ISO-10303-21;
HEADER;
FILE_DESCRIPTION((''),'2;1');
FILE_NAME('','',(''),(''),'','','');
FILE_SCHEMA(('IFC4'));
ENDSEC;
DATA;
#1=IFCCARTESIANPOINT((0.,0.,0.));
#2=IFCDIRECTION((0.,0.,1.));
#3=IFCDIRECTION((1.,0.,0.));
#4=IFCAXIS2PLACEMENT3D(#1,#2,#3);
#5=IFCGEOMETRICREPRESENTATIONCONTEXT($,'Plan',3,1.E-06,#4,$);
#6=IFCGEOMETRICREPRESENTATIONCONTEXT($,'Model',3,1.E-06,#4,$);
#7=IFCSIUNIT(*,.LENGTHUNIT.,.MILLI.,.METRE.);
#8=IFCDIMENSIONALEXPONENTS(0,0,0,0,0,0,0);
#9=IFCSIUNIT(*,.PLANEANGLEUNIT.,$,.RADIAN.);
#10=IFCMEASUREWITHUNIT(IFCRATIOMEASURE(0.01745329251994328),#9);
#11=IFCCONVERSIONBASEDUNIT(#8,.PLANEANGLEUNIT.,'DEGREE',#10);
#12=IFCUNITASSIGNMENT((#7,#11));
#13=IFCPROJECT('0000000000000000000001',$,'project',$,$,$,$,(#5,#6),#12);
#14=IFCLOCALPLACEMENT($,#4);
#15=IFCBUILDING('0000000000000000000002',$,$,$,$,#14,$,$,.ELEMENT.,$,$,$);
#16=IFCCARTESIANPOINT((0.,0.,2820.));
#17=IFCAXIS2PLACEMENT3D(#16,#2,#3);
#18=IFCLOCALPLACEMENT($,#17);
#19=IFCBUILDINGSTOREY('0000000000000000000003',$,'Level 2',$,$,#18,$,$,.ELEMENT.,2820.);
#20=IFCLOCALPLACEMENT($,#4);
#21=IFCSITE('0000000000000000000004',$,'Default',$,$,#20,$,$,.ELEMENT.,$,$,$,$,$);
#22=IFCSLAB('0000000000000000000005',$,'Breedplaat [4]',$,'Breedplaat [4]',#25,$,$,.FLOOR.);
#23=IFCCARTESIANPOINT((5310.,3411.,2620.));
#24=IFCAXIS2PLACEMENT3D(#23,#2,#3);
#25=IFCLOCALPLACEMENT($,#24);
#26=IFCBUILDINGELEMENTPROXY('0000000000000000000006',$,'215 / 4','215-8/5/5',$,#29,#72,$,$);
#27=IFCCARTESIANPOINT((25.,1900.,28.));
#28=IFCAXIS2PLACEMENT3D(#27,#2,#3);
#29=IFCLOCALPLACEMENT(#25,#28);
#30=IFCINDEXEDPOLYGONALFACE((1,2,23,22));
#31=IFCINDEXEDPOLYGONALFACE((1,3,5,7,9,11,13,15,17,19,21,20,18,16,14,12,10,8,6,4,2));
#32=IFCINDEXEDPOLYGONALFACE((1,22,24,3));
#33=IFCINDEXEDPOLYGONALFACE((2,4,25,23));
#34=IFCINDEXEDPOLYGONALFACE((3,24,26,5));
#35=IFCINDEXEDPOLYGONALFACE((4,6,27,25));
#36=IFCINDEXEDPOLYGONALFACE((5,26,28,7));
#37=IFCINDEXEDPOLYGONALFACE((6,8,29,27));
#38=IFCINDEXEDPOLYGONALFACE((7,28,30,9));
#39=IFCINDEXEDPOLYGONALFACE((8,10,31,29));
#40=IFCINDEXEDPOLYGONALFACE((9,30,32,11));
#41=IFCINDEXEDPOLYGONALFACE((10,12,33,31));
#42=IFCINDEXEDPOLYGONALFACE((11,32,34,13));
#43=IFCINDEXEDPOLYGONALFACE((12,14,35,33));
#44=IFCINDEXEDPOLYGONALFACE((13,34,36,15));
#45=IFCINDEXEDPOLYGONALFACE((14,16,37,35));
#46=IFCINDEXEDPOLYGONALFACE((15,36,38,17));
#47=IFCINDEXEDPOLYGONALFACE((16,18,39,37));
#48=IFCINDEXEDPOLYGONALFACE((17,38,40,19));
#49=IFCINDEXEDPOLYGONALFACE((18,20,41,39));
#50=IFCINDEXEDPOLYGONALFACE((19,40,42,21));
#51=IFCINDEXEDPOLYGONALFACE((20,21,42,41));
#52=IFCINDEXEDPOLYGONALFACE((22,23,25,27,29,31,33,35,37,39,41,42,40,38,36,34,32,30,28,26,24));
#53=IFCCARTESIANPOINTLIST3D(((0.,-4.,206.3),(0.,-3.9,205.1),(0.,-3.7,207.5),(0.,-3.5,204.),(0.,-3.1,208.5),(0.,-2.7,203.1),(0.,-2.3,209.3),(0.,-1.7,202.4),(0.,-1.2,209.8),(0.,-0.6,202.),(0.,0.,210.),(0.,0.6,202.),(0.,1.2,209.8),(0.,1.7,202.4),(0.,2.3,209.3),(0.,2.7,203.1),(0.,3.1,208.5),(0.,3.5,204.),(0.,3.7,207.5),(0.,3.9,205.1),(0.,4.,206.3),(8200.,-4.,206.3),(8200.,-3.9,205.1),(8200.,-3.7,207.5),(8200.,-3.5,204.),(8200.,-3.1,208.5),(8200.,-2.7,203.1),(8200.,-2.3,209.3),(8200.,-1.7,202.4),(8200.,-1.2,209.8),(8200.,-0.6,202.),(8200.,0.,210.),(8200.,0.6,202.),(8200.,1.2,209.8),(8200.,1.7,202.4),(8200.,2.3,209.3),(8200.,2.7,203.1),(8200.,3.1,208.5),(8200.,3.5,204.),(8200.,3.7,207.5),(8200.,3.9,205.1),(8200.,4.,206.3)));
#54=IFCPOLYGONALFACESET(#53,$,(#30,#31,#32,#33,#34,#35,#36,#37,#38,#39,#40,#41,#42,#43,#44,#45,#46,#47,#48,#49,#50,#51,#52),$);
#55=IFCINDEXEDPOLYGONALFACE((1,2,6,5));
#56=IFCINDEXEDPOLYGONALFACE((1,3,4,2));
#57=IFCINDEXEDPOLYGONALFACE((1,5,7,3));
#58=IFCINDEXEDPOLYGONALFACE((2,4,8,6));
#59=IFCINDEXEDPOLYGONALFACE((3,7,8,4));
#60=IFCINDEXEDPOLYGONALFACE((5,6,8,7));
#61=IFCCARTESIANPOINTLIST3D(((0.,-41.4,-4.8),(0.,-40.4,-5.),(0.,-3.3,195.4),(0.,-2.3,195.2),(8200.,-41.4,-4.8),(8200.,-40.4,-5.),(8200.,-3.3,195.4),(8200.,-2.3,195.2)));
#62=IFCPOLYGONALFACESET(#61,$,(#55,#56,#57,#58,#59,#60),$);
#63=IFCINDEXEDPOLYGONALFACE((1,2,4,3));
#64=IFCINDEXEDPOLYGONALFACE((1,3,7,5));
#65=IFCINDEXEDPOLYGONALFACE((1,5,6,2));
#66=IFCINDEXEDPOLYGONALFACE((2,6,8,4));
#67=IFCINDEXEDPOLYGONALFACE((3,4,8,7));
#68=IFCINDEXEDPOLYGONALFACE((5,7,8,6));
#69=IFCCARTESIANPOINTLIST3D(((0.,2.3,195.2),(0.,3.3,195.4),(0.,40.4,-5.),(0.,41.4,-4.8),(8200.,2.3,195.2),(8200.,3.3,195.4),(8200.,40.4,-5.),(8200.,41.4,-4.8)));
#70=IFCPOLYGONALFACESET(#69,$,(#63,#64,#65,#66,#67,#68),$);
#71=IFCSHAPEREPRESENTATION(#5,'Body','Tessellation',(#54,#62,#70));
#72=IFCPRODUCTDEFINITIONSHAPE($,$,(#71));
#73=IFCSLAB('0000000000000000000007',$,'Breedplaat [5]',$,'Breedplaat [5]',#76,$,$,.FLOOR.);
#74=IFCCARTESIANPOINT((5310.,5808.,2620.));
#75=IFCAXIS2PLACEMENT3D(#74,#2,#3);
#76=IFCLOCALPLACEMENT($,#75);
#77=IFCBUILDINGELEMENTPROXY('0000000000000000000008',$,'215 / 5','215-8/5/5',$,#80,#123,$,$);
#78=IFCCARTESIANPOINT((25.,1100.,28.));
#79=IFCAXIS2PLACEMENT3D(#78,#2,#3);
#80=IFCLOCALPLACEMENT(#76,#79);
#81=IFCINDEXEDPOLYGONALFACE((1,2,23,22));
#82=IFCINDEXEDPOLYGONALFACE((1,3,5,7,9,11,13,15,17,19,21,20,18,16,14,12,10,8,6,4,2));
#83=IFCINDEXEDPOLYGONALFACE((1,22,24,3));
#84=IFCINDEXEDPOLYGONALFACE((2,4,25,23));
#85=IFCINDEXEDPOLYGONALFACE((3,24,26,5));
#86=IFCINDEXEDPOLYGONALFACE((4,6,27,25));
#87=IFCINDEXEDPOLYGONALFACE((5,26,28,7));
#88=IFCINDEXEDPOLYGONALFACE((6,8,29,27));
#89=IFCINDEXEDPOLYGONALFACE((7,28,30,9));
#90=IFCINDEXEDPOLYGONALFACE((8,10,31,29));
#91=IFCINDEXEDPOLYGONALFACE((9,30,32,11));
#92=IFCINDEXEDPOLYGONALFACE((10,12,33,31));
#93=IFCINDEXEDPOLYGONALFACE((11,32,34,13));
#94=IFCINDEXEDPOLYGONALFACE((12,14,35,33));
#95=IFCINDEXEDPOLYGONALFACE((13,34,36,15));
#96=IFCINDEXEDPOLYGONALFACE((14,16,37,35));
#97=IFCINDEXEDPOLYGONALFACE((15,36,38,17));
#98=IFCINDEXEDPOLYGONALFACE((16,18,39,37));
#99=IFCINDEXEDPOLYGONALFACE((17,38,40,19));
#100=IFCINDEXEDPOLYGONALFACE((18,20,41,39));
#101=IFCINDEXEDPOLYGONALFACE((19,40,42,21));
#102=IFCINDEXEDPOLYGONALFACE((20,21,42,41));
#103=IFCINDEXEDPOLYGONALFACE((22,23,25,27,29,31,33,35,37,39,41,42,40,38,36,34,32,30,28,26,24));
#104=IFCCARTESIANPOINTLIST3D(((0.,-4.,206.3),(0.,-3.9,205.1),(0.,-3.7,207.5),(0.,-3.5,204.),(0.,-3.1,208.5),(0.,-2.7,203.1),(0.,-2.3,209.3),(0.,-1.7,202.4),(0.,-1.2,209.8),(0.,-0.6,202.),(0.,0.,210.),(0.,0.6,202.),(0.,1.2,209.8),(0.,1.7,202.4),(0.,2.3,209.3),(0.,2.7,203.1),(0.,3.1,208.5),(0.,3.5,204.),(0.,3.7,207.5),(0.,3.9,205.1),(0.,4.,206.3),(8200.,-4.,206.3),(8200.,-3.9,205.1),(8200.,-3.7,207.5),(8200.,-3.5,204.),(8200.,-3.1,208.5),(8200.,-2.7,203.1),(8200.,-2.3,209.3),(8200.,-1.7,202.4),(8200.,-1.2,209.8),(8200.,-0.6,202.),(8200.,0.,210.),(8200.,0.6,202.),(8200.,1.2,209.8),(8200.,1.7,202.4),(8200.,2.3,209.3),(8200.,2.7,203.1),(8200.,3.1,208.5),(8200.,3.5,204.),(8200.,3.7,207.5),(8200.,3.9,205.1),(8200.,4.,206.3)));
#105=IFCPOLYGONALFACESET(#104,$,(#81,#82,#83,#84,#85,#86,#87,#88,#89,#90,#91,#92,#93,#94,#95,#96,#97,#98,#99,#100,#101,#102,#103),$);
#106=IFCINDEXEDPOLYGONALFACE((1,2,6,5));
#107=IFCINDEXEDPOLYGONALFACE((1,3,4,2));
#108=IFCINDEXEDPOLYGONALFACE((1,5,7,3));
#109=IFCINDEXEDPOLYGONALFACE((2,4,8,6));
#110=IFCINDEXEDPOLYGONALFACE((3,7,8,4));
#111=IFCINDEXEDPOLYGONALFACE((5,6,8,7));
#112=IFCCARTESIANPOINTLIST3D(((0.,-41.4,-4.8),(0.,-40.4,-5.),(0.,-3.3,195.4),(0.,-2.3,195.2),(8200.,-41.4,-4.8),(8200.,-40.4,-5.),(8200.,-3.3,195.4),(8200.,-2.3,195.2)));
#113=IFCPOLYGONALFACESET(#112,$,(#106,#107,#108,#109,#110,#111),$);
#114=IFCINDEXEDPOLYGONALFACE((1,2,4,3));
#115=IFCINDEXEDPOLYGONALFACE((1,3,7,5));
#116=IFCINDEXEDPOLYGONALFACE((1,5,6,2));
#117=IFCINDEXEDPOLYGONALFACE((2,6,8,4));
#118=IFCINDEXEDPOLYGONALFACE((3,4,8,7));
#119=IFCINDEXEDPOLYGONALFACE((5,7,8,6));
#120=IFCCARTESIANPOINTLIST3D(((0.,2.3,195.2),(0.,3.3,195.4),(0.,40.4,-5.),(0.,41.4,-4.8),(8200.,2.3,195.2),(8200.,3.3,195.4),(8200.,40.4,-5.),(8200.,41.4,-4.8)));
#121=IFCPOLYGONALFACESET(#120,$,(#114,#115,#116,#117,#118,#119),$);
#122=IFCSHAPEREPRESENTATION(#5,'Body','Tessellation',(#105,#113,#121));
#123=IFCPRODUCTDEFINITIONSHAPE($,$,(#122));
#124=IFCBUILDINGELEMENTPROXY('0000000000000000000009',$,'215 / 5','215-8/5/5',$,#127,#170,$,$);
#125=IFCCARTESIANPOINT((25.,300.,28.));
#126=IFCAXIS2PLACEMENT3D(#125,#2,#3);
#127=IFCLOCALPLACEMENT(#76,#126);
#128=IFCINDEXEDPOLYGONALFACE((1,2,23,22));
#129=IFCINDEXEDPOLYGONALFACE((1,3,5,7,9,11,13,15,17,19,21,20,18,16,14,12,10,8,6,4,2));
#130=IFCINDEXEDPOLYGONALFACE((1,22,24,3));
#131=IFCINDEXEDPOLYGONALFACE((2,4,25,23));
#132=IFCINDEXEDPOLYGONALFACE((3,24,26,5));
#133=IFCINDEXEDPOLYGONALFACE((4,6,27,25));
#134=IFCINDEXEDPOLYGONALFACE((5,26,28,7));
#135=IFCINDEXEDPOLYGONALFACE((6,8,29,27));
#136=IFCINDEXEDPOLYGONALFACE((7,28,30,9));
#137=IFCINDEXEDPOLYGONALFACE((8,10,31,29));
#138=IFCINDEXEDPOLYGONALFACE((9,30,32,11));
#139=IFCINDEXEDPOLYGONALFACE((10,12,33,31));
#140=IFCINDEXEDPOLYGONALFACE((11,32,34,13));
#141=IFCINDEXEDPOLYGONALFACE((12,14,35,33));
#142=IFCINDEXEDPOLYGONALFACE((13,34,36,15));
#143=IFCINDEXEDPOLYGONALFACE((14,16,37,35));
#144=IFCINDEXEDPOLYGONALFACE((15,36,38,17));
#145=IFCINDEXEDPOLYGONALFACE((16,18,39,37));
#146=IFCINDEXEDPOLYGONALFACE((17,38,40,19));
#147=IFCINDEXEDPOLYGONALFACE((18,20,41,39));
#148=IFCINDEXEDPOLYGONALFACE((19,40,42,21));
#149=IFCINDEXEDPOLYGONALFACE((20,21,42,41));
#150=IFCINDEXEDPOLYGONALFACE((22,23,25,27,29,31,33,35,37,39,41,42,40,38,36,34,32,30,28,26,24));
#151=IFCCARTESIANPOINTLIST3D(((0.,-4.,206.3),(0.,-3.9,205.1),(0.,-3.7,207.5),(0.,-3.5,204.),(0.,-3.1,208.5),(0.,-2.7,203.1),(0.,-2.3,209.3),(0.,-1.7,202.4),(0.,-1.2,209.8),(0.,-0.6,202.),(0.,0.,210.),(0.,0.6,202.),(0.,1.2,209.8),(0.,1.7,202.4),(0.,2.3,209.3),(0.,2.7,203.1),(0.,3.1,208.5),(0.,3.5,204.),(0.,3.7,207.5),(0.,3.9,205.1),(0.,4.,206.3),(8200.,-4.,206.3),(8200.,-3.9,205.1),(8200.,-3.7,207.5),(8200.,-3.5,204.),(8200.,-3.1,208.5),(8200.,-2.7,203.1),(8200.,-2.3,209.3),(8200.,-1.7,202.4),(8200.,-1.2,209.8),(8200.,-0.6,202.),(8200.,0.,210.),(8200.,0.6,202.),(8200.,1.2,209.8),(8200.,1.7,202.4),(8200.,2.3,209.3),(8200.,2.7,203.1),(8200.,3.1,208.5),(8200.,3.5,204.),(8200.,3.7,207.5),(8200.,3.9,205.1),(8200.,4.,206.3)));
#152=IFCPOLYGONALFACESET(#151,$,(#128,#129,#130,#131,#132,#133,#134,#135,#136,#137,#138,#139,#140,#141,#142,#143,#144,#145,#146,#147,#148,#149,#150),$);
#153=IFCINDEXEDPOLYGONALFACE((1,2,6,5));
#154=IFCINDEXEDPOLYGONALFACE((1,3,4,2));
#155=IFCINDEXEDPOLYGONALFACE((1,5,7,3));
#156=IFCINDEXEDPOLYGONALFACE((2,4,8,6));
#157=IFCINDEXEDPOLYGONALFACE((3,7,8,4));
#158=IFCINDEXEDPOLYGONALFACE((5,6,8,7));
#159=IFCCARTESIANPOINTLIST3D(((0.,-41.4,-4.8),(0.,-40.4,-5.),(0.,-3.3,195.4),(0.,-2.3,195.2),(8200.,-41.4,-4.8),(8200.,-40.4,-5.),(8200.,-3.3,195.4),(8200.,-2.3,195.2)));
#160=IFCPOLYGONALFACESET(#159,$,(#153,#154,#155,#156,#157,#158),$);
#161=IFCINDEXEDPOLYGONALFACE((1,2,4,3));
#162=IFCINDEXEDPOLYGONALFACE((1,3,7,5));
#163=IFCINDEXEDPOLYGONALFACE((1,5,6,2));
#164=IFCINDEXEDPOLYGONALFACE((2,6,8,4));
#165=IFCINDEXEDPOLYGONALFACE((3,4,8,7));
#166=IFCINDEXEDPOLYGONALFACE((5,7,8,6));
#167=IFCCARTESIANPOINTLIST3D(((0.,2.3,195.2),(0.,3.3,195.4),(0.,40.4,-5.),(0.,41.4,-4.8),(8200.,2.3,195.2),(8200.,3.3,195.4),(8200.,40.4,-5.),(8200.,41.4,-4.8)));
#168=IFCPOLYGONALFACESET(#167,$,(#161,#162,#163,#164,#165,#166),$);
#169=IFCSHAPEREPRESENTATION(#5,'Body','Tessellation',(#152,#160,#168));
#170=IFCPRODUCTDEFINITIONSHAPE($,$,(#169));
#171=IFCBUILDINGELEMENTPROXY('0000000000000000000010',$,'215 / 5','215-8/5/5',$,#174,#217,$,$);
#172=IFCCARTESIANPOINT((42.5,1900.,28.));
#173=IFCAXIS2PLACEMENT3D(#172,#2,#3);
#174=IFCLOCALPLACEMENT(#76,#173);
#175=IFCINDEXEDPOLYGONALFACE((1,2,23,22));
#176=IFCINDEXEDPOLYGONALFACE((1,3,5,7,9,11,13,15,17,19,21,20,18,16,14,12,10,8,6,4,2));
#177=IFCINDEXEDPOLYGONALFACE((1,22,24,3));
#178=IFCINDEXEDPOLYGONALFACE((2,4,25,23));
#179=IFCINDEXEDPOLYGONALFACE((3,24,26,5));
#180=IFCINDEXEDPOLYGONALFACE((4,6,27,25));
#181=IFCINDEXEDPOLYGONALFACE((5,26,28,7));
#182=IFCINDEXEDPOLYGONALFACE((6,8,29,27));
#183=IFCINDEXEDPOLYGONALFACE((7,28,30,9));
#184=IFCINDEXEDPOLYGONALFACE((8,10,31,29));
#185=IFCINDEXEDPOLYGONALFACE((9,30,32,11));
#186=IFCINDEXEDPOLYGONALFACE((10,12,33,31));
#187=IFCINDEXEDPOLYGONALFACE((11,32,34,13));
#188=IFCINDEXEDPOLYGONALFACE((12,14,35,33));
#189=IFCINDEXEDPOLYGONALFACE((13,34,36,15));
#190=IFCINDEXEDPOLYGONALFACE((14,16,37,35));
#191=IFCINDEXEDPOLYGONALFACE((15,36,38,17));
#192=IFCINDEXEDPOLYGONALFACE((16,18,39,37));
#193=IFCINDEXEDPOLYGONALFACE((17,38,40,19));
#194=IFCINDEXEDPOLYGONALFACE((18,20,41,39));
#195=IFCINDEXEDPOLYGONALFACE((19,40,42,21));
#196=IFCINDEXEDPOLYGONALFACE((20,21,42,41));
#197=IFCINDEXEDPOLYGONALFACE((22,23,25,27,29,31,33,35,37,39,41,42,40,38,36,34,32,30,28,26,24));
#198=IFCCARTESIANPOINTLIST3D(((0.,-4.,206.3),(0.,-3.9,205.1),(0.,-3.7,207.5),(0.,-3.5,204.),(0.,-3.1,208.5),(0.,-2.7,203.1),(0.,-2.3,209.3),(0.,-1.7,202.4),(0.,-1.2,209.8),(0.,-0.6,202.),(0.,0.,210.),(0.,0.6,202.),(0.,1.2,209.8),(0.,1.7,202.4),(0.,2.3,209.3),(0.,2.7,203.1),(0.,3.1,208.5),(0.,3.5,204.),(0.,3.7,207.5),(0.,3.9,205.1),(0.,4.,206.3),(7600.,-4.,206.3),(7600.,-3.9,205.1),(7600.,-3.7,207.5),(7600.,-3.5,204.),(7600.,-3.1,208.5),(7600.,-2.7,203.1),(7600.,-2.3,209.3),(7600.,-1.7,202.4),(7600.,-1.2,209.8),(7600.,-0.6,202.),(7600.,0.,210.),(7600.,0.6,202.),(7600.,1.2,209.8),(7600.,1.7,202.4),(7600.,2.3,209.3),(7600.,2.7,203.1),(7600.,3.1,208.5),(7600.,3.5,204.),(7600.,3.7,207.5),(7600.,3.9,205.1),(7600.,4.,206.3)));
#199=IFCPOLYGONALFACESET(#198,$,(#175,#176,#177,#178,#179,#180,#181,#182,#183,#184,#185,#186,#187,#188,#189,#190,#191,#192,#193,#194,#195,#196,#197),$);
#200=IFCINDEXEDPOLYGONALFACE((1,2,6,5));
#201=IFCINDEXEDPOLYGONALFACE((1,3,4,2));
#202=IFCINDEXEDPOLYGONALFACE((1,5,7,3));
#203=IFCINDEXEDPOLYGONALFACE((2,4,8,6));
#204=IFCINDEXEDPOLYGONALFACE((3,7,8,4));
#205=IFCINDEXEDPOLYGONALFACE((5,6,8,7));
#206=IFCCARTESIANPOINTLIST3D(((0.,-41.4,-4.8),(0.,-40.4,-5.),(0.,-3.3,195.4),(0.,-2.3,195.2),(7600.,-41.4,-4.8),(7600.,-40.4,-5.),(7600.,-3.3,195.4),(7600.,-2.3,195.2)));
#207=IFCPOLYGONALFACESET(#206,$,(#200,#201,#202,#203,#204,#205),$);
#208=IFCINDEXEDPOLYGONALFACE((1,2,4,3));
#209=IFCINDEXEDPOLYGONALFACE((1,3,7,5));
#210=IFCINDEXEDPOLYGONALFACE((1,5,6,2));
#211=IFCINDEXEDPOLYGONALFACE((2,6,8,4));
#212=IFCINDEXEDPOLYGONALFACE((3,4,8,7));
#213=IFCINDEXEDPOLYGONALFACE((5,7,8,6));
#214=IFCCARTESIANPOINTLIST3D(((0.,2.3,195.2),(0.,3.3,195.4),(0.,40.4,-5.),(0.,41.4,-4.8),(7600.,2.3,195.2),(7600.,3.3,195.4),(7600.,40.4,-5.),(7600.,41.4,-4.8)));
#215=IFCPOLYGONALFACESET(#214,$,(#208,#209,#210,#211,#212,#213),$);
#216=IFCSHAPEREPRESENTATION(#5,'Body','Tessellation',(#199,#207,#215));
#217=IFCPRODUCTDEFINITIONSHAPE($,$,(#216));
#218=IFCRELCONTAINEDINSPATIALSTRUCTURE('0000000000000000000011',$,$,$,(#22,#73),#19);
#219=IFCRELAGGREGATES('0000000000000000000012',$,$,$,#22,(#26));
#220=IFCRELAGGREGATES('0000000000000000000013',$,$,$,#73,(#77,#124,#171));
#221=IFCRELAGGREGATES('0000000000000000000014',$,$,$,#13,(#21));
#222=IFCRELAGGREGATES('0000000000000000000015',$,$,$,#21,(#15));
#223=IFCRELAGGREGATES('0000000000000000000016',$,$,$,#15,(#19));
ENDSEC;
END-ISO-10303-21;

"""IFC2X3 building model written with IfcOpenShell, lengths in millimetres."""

from ifc_helpers import new_model, entity, si_unit, converted_unit, frame, origin_with_axes, origin_2d_with_axis, place, context, project, spatial, rectangle, circle, extrude, element, aggregate, save


model = new_model("IFC2X3")

# Units and contexts
plan_context = context("Plan", 3, precision=1e-06, world=origin_with_axes())
model_context = context("Model", 3, precision=1e-06, world=origin_with_axes())
ifc_project = project(units=[si_unit("LENGTHUNIT", "METRE", prefix="MILLI"), converted_unit("PLANEANGLEUNIT", "DEGREE", entity("IfcRatioMeasure", 0.01745329251994328), si_unit("PLANEANGLEUNIT", "RADIAN"), dimensions=[0, 0, 0, 0, 0, 0, 0])], contexts=[plan_context, model_context])

# Site, building, storey
site_placement = place(None, origin_with_axes())
site = spatial("IfcSite", under=ifc_project, at=site_placement, Name="Default", CompositionType="ELEMENT")
building_placement = place(None, origin_with_axes())
building = spatial("IfcBuilding", under=site, at=building_placement, CompositionType="ELEMENT")
storey_placement = place(None, frame((0.0, 0.0, 2820.0), z_axis=(0.0, 0.0, 1.0), x_axis=(1.0, 0.0, 0.0)))
storey = spatial("IfcBuildingStorey", under=building, at=storey_placement, Name="Level 2", CompositionType="ELEMENT", Elevation=2820.0)

# Slabs, building element proxies
slab_1_placement = place(None, frame((5310.0, 3411.0, 2620.0), z_axis=(0.0, 0.0, 1.0), x_axis=(1.0, 0.0, 0.0)))
slab_1 = element("IfcSlab", 1, at=slab_1_placement, inside=storey, Name="Breedplaat [4]", ObjectType="Breedplaat [4]", PredefinedType="FLOOR")
proxy_1_placement = place(slab_1_placement, frame((25.0, 1900.0, 28.0), z_axis=(0.0, 0.0, 1.0), x_axis=(1.0, 0.0, 0.0)))
proxy_1 = element("IfcBuildingElementProxy", 2, at=proxy_1_placement, Name="215 / 4", Description="215-8/5/5", context=plan_context, shape_type="SweptSolid", body=[
    extrude(circle(Radius=4.0, at=origin_2d_with_axis()), frame((0.0, 0.0, 206.0), z_axis=(1.0, 0.0, 0.0), x_axis=(0.0, 0.0, 1.0)), (0.0, 0.0, 1.0), 8200.0),
    extrude(rectangle(XDim=203.8, YDim=1.0, at=origin_2d_with_axis()), frame((0.0, -21.9, 95.2), z_axis=(1.0, 0.0, 0.0), x_axis=(0.0, 0.187112, 0.982339)), (0.0, 0.0, 1.0), 8200.0),
    extrude(rectangle(XDim=203.8, YDim=1.0, at=origin_2d_with_axis()), frame((0.0, 21.9, 95.2), z_axis=(1.0, 0.0, 0.0), x_axis=(0.0, -0.187112, 0.982339)), (0.0, 0.0, 1.0), 8200.0),
])
aggregate(slab_1, [proxy_1])
slab_2_placement = place(None, frame((5310.0, 5808.0, 2620.0), z_axis=(0.0, 0.0, 1.0), x_axis=(1.0, 0.0, 0.0)))
slab_2 = element("IfcSlab", 3, at=slab_2_placement, inside=storey, Name="Breedplaat [5]", ObjectType="Breedplaat [5]", PredefinedType="FLOOR")
proxy_2_placement = place(slab_2_placement, frame((25.0, 1100.0, 28.0), z_axis=(0.0, 0.0, 1.0), x_axis=(1.0, 0.0, 0.0)))
proxy_2 = element("IfcBuildingElementProxy", 4, at=proxy_2_placement, Name="215 / 5", Description="215-8/5/5", context=plan_context, shape_type="SweptSolid", body=[
    extrude(circle(Radius=4.0, at=origin_2d_with_axis()), frame((0.0, 0.0, 206.0), z_axis=(1.0, 0.0, 0.0), x_axis=(0.0, 0.0, 1.0)), (0.0, 0.0, 1.0), 8200.0),
    extrude(rectangle(XDim=203.8, YDim=1.0, at=origin_2d_with_axis()), frame((0.0, -21.9, 95.2), z_axis=(1.0, 0.0, 0.0), x_axis=(0.0, 0.187112, 0.982339)), (0.0, 0.0, 1.0), 8200.0),
    extrude(rectangle(XDim=203.8, YDim=1.0, at=origin_2d_with_axis()), frame((0.0, 21.9, 95.2), z_axis=(1.0, 0.0, 0.0), x_axis=(0.0, -0.187112, 0.982339)), (0.0, 0.0, 1.0), 8200.0),
])
proxy_3_placement = place(slab_2_placement, frame((25.0, 300.0, 28.0), z_axis=(0.0, 0.0, 1.0), x_axis=(1.0, 0.0, 0.0)))
proxy_3 = element("IfcBuildingElementProxy", 5, at=proxy_3_placement, Name="215 / 5", Description="215-8/5/5", context=plan_context, shape_type="SweptSolid", body=[
    extrude(circle(Radius=4.0, at=origin_2d_with_axis()), frame((0.0, 0.0, 206.0), z_axis=(1.0, 0.0, 0.0), x_axis=(0.0, 0.0, 1.0)), (0.0, 0.0, 1.0), 8200.0),
    extrude(rectangle(XDim=203.8, YDim=1.0, at=origin_2d_with_axis()), frame((0.0, -21.9, 95.2), z_axis=(1.0, 0.0, 0.0), x_axis=(0.0, 0.187112, 0.982339)), (0.0, 0.0, 1.0), 8200.0),
    extrude(rectangle(XDim=203.8, YDim=1.0, at=origin_2d_with_axis()), frame((0.0, 21.9, 95.2), z_axis=(1.0, 0.0, 0.0), x_axis=(0.0, -0.187112, 0.982339)), (0.0, 0.0, 1.0), 8200.0),
])
proxy_4_placement = place(slab_2_placement, frame((42.5, 1900.0, 28.0), z_axis=(0.0, 0.0, 1.0), x_axis=(1.0, 0.0, 0.0)))
proxy_4 = element("IfcBuildingElementProxy", 6, at=proxy_4_placement, Name="215 / 5", Description="215-8/5/5", context=plan_context, shape_type="SweptSolid", body=[
    extrude(circle(Radius=4.0, at=origin_2d_with_axis()), frame((0.0, 0.0, 206.0), z_axis=(1.0, 0.0, 0.0), x_axis=(0.0, 0.0, 1.0)), (0.0, 0.0, 1.0), 7600.0),
    extrude(rectangle(XDim=203.8, YDim=1.0, at=origin_2d_with_axis()), frame((0.0, -21.9, 95.2), z_axis=(1.0, 0.0, 0.0), x_axis=(0.0, 0.187112, 0.982339)), (0.0, 0.0, 1.0), 7600.0),
    extrude(rectangle(XDim=203.8, YDim=1.0, at=origin_2d_with_axis()), frame((0.0, 21.9, 95.2), z_axis=(1.0, 0.0, 0.0), x_axis=(0.0, -0.187112, 0.982339)), (0.0, 0.0, 1.0), 7600.0),
])
aggregate(slab_2, [proxy_2, proxy_3, proxy_4])

save(model, "model.ifc")
